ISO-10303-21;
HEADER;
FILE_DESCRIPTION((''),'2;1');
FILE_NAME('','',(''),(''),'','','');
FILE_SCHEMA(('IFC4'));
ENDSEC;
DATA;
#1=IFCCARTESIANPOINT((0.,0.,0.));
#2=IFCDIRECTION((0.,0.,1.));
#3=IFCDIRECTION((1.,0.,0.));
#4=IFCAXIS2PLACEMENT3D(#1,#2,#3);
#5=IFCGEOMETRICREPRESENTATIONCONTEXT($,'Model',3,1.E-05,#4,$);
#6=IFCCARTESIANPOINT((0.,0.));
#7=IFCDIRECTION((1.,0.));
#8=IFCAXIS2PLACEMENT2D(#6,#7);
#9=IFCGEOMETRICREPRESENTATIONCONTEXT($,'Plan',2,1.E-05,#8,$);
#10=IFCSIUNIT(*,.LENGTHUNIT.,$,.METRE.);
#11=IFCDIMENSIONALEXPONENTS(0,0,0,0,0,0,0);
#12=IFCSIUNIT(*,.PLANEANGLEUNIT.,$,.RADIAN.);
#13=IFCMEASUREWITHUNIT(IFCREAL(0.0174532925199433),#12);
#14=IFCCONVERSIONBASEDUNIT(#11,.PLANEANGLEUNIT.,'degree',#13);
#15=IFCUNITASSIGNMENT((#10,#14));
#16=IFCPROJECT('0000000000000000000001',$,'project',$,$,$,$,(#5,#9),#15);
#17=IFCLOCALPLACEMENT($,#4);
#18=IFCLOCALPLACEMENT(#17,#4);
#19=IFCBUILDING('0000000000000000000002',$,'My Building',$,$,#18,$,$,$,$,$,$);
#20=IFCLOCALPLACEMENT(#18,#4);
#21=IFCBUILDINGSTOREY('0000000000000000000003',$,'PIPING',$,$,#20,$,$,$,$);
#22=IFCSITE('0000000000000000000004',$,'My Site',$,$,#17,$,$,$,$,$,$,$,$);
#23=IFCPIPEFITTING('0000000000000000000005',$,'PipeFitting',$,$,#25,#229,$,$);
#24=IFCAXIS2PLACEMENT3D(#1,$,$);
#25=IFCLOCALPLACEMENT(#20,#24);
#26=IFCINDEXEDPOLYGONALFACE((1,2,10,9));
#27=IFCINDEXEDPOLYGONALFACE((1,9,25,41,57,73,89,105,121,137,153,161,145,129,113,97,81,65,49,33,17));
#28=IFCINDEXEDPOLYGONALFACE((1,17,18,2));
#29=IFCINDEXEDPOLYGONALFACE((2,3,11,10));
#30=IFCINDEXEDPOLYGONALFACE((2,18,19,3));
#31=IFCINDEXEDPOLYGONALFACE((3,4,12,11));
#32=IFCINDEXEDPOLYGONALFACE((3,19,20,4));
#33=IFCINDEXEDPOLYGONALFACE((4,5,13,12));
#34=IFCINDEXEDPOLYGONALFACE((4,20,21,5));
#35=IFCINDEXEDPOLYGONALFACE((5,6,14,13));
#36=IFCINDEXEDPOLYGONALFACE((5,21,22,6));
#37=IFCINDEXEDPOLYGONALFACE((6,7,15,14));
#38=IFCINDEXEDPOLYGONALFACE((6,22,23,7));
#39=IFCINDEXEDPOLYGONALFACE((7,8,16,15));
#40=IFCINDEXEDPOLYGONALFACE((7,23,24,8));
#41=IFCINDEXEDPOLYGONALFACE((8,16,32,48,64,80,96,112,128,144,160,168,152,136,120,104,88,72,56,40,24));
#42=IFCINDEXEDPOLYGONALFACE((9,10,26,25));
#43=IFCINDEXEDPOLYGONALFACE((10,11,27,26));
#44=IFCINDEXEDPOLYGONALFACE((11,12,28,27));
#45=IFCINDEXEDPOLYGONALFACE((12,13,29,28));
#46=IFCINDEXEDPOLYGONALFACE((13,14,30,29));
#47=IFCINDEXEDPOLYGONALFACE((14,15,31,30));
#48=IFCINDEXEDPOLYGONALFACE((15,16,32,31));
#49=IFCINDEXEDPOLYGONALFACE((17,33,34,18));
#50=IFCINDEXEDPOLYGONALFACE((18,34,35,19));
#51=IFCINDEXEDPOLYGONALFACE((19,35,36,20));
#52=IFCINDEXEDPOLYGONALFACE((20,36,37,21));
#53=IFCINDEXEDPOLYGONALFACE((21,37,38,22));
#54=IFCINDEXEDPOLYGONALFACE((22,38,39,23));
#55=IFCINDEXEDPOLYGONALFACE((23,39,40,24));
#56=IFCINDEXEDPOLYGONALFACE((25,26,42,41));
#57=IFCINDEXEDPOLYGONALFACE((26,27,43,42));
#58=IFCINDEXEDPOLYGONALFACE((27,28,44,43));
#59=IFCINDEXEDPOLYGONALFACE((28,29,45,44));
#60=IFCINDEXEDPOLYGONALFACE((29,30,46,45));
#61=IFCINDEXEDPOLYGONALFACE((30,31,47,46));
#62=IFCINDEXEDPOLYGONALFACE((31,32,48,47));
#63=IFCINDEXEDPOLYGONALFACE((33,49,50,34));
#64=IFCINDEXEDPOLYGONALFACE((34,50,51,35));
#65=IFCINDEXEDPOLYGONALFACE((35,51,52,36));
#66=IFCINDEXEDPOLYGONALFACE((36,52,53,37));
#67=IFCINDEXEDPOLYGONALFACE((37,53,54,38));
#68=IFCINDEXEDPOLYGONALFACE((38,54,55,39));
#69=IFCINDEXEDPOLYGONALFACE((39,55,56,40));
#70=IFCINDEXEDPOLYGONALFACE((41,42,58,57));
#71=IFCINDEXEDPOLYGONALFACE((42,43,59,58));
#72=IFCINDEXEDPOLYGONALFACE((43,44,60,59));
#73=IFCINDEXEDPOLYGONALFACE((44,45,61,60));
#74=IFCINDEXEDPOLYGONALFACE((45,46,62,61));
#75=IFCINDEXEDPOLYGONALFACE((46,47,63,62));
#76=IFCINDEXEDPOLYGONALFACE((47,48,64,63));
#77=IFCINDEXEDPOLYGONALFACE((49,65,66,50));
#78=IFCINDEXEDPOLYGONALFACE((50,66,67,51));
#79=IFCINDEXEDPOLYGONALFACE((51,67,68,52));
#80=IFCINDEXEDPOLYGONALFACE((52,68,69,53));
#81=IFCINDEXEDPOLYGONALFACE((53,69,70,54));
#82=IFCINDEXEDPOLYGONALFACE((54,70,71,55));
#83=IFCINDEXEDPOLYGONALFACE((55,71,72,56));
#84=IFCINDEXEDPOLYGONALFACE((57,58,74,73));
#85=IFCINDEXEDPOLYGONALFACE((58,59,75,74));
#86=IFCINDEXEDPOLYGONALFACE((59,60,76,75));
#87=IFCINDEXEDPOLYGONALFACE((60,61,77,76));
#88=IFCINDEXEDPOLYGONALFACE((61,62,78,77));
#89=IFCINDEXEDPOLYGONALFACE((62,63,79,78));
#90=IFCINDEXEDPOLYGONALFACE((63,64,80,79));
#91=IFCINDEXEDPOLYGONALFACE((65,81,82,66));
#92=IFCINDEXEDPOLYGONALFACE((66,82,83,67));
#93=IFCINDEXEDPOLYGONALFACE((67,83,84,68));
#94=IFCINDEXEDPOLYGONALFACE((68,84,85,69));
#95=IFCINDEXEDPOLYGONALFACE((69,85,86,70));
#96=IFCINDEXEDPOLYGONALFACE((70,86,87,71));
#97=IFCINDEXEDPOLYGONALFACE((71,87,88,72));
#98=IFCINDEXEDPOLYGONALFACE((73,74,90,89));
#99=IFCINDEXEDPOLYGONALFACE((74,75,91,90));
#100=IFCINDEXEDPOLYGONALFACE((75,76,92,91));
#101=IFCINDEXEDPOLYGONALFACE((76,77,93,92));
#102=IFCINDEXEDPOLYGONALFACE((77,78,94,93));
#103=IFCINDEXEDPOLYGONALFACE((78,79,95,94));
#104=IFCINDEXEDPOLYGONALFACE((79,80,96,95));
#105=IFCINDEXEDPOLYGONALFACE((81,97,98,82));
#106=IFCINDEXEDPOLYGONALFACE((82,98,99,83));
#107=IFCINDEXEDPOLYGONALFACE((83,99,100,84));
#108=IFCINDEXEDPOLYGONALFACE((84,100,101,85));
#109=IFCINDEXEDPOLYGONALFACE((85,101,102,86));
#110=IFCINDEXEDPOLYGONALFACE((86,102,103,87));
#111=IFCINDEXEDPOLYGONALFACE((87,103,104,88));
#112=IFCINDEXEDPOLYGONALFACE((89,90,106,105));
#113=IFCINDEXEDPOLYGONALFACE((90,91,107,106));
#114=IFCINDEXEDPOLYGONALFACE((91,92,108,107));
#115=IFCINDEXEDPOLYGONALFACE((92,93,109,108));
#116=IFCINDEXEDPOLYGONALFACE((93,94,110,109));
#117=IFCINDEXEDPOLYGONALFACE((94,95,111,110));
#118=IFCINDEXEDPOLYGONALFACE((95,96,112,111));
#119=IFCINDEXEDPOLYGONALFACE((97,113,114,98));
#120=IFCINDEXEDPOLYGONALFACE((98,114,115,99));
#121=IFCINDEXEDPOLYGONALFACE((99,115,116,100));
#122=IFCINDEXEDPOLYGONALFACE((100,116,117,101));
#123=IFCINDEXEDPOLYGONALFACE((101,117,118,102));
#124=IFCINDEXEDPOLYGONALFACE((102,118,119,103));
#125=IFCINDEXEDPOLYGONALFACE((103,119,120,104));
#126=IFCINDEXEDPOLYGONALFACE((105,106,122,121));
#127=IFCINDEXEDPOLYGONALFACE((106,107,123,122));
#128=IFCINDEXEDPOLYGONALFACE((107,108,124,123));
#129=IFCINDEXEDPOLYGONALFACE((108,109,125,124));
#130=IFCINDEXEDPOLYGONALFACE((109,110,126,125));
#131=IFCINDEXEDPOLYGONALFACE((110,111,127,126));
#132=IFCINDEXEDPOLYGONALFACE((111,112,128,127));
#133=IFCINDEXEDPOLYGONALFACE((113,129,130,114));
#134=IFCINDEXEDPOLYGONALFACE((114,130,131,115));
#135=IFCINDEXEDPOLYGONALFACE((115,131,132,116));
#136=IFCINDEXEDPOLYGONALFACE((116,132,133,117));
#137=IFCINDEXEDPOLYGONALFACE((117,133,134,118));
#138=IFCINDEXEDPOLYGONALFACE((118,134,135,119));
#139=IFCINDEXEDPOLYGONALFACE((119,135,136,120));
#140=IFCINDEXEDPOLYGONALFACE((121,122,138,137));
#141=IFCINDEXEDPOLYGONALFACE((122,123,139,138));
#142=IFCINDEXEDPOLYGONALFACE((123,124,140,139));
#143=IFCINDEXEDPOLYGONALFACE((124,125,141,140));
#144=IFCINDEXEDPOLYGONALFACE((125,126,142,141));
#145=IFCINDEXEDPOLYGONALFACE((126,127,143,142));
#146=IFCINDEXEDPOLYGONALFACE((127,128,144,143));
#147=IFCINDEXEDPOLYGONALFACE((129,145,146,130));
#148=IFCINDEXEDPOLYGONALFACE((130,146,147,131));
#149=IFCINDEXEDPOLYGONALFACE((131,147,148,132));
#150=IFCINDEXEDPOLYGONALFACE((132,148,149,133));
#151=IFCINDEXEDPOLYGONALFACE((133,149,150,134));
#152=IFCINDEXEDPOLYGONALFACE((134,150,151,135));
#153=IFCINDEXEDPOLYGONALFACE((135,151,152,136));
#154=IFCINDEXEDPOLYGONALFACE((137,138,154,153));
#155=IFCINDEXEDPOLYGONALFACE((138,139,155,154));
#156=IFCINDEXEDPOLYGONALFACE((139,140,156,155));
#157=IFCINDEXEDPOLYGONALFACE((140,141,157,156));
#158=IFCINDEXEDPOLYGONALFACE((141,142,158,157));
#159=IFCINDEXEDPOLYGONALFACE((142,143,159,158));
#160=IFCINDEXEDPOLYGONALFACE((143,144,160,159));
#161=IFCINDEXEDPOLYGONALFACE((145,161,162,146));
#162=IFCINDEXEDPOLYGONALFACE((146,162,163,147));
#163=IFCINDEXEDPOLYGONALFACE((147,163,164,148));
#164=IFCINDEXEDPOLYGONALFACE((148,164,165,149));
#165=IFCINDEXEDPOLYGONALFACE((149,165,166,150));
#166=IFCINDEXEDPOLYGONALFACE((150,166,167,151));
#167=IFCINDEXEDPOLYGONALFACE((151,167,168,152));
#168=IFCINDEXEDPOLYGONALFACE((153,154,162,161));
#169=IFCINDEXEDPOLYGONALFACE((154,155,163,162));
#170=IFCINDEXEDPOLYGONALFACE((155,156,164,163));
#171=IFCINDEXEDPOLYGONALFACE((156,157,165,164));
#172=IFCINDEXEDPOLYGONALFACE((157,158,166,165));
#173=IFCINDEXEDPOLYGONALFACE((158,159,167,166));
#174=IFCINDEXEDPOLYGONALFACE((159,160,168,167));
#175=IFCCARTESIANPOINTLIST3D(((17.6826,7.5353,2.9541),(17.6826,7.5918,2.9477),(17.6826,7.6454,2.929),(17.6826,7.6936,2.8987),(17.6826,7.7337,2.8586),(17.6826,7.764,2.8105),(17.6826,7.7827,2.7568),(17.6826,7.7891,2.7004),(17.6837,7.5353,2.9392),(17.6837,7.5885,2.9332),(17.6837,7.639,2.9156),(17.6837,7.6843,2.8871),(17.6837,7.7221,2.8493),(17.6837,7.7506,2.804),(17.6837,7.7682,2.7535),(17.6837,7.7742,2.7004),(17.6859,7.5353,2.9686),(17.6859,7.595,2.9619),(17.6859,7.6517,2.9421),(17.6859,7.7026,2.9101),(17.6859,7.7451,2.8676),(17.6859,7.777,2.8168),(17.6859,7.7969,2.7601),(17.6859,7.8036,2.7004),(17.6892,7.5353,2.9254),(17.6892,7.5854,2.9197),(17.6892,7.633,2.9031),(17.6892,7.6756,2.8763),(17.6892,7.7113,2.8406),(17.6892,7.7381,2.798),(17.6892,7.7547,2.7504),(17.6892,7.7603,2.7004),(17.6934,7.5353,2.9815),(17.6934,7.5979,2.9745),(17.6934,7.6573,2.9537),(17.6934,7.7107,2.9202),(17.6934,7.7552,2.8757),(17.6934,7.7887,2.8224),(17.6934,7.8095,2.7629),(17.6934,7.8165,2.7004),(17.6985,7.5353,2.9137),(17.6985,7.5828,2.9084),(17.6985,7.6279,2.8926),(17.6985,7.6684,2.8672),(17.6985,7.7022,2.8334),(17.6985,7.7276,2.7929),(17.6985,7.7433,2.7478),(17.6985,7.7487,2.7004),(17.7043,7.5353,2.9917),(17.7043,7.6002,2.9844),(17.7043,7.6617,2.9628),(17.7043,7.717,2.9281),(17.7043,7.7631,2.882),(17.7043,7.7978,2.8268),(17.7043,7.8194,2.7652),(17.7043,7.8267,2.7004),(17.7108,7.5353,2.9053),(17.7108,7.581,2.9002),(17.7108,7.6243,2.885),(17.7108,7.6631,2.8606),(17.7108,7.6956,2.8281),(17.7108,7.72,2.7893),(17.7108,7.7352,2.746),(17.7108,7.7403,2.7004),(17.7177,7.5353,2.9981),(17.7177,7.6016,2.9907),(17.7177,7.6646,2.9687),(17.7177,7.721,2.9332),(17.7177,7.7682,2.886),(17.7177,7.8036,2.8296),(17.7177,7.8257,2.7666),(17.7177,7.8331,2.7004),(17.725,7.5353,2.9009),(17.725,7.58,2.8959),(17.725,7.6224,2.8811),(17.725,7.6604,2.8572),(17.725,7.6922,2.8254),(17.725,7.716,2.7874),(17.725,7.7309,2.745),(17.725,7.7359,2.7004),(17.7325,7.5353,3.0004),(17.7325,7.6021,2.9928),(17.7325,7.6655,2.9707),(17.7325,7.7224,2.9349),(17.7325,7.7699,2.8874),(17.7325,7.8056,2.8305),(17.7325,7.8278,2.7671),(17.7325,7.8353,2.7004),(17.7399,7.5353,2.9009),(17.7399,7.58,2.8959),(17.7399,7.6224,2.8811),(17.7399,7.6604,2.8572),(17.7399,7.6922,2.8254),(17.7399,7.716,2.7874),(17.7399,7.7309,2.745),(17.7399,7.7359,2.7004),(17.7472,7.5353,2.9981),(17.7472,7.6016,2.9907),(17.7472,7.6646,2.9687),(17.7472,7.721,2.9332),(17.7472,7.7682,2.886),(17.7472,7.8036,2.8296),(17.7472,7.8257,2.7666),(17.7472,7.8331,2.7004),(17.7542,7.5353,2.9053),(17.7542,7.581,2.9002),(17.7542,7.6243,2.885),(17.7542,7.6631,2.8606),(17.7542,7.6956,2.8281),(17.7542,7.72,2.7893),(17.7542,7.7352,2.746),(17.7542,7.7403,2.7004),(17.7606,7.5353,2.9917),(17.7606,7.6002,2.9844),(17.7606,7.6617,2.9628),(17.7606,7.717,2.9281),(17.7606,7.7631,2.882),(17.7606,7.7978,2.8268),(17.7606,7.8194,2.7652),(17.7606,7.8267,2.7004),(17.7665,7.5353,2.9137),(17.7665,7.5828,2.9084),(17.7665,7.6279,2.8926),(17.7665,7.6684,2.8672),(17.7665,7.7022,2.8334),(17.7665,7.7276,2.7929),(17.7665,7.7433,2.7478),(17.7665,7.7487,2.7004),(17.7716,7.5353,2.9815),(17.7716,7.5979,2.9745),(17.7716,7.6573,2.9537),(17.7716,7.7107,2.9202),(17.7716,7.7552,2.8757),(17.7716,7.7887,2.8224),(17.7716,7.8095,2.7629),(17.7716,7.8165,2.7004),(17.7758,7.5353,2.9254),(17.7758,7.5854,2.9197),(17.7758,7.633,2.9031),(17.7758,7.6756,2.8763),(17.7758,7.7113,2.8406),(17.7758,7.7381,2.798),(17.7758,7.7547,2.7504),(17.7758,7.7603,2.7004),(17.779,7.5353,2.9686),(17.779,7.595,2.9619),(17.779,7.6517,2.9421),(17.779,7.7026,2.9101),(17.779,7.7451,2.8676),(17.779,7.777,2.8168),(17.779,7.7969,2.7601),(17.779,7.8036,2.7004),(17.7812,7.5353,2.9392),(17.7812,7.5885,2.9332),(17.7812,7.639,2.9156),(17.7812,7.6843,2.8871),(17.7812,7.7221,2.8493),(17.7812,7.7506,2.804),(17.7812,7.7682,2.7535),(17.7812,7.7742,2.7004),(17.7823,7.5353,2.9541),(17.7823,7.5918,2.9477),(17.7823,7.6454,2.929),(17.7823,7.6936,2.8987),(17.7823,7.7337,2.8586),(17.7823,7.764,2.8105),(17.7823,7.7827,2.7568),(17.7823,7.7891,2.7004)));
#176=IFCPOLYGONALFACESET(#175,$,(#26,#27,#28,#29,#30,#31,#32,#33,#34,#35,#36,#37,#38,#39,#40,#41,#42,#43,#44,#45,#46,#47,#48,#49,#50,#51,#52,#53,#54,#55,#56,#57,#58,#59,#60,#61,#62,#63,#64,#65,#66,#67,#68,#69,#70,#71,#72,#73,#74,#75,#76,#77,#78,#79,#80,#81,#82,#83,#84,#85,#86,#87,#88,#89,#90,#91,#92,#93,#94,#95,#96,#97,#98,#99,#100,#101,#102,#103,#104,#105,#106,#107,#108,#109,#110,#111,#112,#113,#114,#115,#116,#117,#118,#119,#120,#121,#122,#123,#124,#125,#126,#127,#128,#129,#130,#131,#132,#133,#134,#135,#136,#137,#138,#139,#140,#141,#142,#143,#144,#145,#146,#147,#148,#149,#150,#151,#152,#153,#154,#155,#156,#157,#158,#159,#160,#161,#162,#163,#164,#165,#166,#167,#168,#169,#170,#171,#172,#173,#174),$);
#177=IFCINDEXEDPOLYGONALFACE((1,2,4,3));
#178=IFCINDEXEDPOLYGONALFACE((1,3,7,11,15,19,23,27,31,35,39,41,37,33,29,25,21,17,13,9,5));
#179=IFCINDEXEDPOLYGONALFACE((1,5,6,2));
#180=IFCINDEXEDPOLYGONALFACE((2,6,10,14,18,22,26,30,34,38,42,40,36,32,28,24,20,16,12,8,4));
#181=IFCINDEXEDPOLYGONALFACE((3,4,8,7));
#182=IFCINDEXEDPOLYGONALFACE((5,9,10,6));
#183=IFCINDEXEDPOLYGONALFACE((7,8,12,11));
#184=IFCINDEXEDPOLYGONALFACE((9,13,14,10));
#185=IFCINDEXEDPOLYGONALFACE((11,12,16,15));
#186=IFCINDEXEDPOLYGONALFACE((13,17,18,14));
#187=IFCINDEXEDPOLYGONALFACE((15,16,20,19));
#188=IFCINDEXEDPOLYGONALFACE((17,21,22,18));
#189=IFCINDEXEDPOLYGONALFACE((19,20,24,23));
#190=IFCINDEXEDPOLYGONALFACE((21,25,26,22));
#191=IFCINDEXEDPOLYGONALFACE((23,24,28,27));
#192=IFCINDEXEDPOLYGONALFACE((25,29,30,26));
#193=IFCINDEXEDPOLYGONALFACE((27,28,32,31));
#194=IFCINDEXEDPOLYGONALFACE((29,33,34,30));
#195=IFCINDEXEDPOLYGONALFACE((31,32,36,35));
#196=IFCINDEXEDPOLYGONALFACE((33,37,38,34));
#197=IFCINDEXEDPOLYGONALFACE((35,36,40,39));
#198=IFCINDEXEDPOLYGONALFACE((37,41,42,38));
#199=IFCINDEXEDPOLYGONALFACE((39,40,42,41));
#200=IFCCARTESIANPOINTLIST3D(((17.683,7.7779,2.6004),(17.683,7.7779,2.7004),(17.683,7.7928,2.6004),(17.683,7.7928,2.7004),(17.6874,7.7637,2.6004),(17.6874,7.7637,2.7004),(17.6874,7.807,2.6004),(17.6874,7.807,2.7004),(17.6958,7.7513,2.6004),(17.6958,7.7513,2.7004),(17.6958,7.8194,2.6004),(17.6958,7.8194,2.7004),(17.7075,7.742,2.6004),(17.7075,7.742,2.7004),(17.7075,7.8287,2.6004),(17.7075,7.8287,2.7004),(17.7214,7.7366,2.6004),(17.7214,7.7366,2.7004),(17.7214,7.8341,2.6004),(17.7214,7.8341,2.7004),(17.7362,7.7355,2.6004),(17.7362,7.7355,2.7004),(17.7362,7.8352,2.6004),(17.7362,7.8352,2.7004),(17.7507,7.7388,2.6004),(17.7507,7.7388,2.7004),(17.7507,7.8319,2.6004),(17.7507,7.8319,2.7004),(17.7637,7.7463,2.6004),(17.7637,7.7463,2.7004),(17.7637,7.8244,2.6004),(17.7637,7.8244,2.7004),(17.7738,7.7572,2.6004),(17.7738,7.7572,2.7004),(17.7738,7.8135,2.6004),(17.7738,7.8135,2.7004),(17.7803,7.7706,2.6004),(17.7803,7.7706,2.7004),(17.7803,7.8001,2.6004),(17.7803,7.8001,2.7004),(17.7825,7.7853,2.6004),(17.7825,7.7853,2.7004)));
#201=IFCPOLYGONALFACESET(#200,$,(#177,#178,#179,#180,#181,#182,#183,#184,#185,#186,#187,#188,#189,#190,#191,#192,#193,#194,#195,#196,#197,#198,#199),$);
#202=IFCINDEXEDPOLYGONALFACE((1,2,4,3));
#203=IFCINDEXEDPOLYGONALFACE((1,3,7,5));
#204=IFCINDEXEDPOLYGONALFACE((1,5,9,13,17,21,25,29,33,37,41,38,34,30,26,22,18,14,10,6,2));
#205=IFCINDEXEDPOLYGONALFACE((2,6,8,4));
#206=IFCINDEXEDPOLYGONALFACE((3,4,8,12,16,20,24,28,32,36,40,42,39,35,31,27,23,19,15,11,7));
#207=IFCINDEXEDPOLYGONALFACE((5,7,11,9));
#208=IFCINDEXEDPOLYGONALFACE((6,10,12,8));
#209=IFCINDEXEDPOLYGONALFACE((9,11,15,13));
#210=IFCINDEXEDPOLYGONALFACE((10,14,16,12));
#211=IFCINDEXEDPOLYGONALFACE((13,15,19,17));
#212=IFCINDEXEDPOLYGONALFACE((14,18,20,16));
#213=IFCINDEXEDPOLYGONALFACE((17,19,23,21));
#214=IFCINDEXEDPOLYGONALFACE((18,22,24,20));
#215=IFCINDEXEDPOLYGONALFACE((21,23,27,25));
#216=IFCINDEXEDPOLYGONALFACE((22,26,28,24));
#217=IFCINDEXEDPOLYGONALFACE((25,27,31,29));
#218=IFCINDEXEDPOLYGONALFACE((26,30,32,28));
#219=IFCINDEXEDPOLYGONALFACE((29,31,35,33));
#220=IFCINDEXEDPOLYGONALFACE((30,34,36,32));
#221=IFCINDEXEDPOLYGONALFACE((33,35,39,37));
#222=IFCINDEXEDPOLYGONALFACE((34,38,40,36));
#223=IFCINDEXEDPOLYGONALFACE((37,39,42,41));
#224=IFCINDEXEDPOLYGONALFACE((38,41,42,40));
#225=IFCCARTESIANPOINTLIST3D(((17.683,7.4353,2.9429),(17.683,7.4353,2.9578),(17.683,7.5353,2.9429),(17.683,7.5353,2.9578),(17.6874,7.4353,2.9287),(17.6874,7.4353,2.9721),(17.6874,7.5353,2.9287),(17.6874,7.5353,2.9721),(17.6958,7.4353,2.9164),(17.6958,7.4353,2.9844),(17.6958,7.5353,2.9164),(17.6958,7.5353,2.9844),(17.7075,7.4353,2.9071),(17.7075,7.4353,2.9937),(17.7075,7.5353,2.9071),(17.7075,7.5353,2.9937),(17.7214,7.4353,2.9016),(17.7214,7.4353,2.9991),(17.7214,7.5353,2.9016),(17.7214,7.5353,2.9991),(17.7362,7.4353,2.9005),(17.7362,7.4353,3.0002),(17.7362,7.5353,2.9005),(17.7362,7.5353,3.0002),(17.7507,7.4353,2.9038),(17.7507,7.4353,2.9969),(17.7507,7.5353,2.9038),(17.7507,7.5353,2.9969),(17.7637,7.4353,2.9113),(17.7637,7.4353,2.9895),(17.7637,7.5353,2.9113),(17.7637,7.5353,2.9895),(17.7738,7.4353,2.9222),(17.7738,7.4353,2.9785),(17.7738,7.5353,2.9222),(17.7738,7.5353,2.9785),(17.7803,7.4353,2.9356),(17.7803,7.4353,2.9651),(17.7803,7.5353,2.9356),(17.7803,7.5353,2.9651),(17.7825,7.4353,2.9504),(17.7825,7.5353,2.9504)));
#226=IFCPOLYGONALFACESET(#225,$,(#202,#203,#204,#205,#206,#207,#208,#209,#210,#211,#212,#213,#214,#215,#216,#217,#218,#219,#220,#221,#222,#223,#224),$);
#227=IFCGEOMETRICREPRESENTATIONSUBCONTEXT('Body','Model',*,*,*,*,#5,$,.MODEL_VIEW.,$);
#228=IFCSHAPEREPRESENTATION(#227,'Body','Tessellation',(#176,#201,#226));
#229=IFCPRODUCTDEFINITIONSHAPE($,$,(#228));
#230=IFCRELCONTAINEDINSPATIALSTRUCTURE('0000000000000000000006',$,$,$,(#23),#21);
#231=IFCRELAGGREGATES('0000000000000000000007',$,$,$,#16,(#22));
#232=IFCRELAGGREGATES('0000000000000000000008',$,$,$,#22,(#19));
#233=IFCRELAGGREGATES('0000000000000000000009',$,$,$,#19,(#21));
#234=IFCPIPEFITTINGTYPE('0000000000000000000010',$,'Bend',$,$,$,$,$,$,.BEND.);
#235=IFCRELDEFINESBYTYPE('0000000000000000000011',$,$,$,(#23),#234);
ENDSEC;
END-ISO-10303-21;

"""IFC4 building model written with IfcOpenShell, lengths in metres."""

from ifc_helpers import new_model, entity, si_unit, converted_unit, frame, origin_with_axes, origin_2d_with_axis, place, context, subcontext, project, spatial, circle, extrude, source, transform, mapped, type_object, type_shapes, element, save


model = new_model("IFC4")

# Units and contexts
model_context = context("Model", 3, precision=1e-05, world=origin_with_axes())
plan_context = context("Plan", 2, precision=1e-05, world=origin_2d_with_axis())
body_context = subcontext(model_context, "Body", "Model", "MODEL_VIEW")
ifc_project = project(units=[si_unit("LENGTHUNIT", "METRE"), converted_unit("PLANEANGLEUNIT", "degree", entity("IfcReal", 0.0174532925199433), si_unit("PLANEANGLEUNIT", "RADIAN"), dimensions=[0, 0, 0, 0, 0, 0, 0])], contexts=[model_context, plan_context])

# Site, building, storey
site_placement = place(None, origin_with_axes())
site = spatial("IfcSite", under=ifc_project, at=site_placement, Name="My Site")
building_placement = place(site_placement, origin_with_axes())
building = spatial("IfcBuilding", under=site, at=building_placement, Name="My Building")
storey_placement = place(building_placement, origin_with_axes())
storey = spatial("IfcBuildingStorey", under=building, at=storey_placement, Name="PIPING")

# Pipe fitting
pipe_fitting_type_1 = type_object("IfcPipeFittingType", Name="Bend", PredefinedType="BEND")
shared_shape = source(origin_with_axes(), body_context, "Body", "SolidModel", [
    entity("IfcSweptDiskSolid", entity("IfcIndexedPolyCurve", entity("IfcCartesianPointList3D", [[0.0, 0.0, -0.1], [0.0, 0.0732, -0.2768], [0.0, 0.25, -0.35]]), [entity("IfcArcIndex", [1, 2, 3])]), 0.05),
    extrude(circle(Radius=0.05), origin_with_axes(), (0.0, 0.0, -1.0), 0.1),
    extrude(circle(Radius=0.05), frame((0.0, 0.25, -0.35), z_axis=(0.0, 1.0, 0.0), x_axis=(1.0, 0.0, 0.0)), (0.0, 0.0, 1.0), 0.1),
])
type_shapes(pipe_fitting_type_1, [shared_shape])
for number, where, z_axis, x_axis, name in (
    (1, (17.7325, 7.7853, 2.6004), (0.0, 0.0, -1.0), (1.0, 0.0, 0.0), "PipeFitting"),
):
    element("IfcPipeFitting", number, at=place(storey_placement, frame(where, z_axis=z_axis, x_axis=x_axis)), inside=storey, type_object=pipe_fitting_type_1, Name=name, context=body_context, shape_type="MappedRepresentation", body=[
        mapped(shared_shape, transform((0.0, 0.0, 0.0), x_axis=(1.0, 0.0, 0.0), y_axis=(0.0, 1.0, 0.0), z_axis=(0.0, 0.0, 1.0), scale=1.0)),
    ])

save(model, "model.ifc")
